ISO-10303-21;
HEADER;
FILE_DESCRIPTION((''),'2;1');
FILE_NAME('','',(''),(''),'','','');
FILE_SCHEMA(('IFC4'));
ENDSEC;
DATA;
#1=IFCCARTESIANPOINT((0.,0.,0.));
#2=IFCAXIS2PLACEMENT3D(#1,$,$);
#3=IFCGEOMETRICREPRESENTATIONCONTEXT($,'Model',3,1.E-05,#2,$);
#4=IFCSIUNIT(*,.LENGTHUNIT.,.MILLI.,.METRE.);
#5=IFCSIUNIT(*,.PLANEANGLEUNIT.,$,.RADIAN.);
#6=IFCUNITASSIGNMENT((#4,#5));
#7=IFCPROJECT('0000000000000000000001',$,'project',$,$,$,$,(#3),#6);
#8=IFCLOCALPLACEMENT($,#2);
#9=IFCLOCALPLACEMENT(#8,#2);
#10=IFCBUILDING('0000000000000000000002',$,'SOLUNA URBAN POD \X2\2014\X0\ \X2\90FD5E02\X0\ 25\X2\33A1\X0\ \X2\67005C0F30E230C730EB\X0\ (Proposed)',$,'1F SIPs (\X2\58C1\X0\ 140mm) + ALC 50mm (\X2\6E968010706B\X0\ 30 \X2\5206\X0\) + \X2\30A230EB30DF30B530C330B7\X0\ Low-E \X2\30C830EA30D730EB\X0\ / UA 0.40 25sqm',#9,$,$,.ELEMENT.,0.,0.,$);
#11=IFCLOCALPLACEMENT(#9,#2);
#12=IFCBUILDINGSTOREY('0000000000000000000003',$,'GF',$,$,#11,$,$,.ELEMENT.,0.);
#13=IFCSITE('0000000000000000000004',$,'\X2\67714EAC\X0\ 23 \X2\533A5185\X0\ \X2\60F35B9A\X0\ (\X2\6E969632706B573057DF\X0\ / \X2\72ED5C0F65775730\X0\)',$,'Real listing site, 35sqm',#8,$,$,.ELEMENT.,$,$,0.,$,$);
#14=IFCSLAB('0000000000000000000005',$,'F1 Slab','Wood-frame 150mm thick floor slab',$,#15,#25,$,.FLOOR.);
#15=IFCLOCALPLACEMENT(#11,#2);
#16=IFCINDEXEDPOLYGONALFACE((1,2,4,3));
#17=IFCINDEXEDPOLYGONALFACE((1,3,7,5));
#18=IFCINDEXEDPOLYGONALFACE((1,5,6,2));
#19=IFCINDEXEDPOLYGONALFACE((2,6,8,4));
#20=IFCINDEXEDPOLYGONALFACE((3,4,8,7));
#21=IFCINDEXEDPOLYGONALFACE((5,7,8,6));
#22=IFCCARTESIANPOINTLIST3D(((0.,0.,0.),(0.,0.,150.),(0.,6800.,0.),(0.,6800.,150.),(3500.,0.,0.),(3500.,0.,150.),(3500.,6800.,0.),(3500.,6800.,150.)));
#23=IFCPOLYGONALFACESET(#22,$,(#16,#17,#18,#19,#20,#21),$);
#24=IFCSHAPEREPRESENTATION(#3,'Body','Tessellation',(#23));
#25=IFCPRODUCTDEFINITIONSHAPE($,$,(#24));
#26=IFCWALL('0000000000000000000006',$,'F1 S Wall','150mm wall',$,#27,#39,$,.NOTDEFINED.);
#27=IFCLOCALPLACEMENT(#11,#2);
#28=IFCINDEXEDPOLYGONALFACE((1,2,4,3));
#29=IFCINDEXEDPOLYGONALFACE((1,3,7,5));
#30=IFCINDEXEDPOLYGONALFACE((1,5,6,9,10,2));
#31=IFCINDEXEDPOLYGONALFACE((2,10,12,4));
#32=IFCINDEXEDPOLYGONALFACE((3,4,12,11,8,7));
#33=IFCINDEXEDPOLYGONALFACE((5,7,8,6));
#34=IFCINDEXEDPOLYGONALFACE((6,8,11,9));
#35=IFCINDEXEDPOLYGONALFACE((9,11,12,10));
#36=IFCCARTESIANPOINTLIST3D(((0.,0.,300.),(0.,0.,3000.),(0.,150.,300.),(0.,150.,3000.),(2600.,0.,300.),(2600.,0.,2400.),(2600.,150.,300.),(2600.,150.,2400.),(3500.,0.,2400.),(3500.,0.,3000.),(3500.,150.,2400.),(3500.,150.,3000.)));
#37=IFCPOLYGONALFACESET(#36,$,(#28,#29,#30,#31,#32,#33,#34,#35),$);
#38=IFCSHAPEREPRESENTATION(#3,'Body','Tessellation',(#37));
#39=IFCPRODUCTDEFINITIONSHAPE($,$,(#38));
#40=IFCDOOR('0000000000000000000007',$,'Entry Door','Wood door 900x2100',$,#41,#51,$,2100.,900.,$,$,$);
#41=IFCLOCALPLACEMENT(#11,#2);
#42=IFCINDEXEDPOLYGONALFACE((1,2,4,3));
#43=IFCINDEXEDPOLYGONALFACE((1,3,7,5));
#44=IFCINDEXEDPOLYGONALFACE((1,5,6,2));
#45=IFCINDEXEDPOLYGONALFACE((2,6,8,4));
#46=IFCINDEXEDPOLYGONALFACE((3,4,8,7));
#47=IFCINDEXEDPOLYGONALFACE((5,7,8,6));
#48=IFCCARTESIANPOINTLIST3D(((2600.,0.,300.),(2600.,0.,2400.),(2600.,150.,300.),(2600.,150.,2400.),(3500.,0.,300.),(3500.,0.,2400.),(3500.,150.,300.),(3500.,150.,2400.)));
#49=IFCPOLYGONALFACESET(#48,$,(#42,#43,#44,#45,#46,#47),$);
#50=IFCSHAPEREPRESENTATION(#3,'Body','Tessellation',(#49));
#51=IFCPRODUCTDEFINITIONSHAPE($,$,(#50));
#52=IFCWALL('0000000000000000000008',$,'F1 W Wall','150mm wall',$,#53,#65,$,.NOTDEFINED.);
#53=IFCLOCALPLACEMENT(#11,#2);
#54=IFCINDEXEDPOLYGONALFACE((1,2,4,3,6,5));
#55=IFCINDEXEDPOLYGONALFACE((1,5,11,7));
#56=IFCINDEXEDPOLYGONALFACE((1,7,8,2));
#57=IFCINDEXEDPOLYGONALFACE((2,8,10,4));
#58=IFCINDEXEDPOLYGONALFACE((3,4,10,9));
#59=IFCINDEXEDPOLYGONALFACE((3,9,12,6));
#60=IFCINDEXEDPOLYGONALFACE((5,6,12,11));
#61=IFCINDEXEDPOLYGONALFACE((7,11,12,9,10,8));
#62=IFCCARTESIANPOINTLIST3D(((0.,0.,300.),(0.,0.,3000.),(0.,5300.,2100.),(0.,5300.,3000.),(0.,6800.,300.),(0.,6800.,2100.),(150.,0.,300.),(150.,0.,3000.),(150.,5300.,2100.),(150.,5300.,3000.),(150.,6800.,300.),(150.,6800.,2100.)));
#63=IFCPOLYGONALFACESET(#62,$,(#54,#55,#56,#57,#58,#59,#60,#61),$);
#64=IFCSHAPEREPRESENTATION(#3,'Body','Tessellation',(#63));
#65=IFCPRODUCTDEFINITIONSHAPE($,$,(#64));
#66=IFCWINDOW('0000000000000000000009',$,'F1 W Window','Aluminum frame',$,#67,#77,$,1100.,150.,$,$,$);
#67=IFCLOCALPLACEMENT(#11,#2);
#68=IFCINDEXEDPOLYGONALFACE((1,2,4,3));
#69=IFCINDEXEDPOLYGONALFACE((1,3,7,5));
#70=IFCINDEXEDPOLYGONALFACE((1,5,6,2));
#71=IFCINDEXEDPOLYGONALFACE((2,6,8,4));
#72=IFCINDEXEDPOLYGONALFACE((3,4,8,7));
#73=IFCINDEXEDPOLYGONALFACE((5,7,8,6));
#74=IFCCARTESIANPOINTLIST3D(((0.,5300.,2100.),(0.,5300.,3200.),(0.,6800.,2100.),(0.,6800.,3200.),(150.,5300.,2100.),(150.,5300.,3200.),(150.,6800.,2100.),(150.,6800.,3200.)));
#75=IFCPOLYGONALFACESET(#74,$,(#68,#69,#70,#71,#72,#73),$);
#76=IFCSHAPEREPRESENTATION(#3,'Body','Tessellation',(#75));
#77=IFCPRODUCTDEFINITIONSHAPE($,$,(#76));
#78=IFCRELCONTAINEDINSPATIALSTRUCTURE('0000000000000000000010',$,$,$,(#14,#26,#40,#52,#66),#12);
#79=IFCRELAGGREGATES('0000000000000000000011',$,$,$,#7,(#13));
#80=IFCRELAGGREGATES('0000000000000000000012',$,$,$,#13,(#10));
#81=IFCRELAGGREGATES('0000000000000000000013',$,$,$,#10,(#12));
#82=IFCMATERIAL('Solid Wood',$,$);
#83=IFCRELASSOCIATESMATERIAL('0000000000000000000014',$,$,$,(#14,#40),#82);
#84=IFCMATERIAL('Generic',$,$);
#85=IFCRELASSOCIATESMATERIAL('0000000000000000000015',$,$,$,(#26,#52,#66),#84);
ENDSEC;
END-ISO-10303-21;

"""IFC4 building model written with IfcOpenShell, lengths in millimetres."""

from ifc_helpers import new_model, si_unit, frame, frame_2d, origin, place, context, project, spatial, rectangle, extrude, material, element, fill, save


model = new_model("IFC4")

# Units and contexts
model_context = context("Model", 3, precision=1e-05, world=origin())
ifc_project = project(units=[si_unit("LENGTHUNIT", "METRE", prefix="MILLI"), si_unit("PLANEANGLEUNIT", "RADIAN")], contexts=[model_context])

# Site, building, storey
site_placement = place(None, origin())
site = spatial("IfcSite", under=ifc_project, at=site_placement, Name="東京 23 区内 想定 (準防火地域 / 狭小敷地)", ObjectType="Real listing site, 35sqm", CompositionType="ELEMENT", RefElevation=0.0)
building_placement = place(site_placement, origin())
building = spatial("IfcBuilding", under=site, at=building_placement, Name="SOLUNA URBAN POD — 都市 25㎡ 最小モデル (Proposed)", ObjectType="1F SIPs (壁 140mm) + ALC 50mm (準耐火 30 分) + アルミサッシ Low-E トリプル / UA 0.40 25sqm", CompositionType="ELEMENT", ElevationOfRefHeight=0.0, ElevationOfTerrain=0.0)
storey_placement = place(building_placement, origin())
storey = spatial("IfcBuildingStorey", under=building, at=storey_placement, Name="GF", CompositionType="ELEMENT", Elevation=0.0)

# Slab
ifc_material_1 = material(Name="Solid Wood")
slab_placement = place(storey_placement, origin())
element("IfcSlab", 1, at=slab_placement, inside=storey, material=ifc_material_1, Name="F1 Slab", Description="Wood-frame 150mm thick floor slab", PredefinedType="FLOOR", context=model_context, shape_type="SweptSolid", body=[
    extrude(rectangle(XDim=3500.0, YDim=6800.0, at=frame_2d((1750.0, 3400.0))), origin(), (0.0, 0.0, 1.0), 150.0),
])

# Shared definitions
ifc_material_2 = material(Name="Generic")

# Wall, opening, door
wall_1_placement = place(storey_placement, frame((0.0, 0.0, 150.0)))
wall_1 = element("IfcWall", 2, at=wall_1_placement, inside=storey, material=ifc_material_2, Name="F1 S Wall", Description="150mm wall", PredefinedType="NOTDEFINED", context=model_context, shape_type="SweptSolid", body=[
    extrude(rectangle(XDim=3500.0, YDim=150.0, at=frame_2d((1750.0, 75.0))), frame((0.0, 0.0, 150.0)), (0.0, 0.0, 1.0), 2700.0),
])
opening_1_placement = place(storey_placement, frame((1300.0, 0.0, 150.0)))
opening_1 = element("IfcOpeningElement", 3, at=opening_1_placement, cuts=wall_1, PredefinedType="NOTDEFINED", context=model_context, shape_type="SweptSolid", body=[
    extrude(rectangle(XDim=900.0, YDim=150.0, at=frame_2d((450.0, 75.0))), frame((1300.0, 0.0, 150.0)), (0.0, 0.0, 1.0), 2100.0),
])
door_placement = place(storey_placement, frame((1300.0, 0.0, 150.0)))
door = element("IfcDoor", 4, at=door_placement, inside=storey, material=ifc_material_1, Name="Entry Door", Description="Wood door 900x2100", OverallHeight=2100.0, OverallWidth=900.0, context=model_context, shape_type="SweptSolid", body=[
    extrude(rectangle(XDim=900.0, YDim=150.0, at=frame_2d((450.0, 75.0))), frame((1300.0, 0.0, 150.0)), (0.0, 0.0, 1.0), 2100.0),
])
fill(opening_1, door)

# Wall, opening, window
wall_2_placement = place(storey_placement, frame((0.0, 0.0, 150.0)))
wall_2 = element("IfcWall", 5, at=wall_2_placement, inside=storey, material=ifc_material_2, Name="F1 W Wall", Description="150mm wall", PredefinedType="NOTDEFINED", context=model_context, shape_type="SweptSolid", body=[
    extrude(rectangle(XDim=150.0, YDim=6800.0, at=frame_2d((75.0, 3400.0))), frame((0.0, 0.0, 150.0)), (0.0, 0.0, 1.0), 2700.0),
])
opening_2_placement = place(storey_placement, frame((0.0, 2650.0, 1050.0)))
opening_2 = element("IfcOpeningElement", 6, at=opening_2_placement, cuts=wall_2, PredefinedType="NOTDEFINED", context=model_context, shape_type="SweptSolid", body=[
    extrude(rectangle(XDim=150.0, YDim=1500.0, at=frame_2d((75.0, 750.0))), frame((0.0, 2650.0, 1050.0)), (0.0, 0.0, 1.0), 1100.0),
])
window_1_placement = place(storey_placement, frame((0.0, 2650.0, 1050.0)))
window_1 = element("IfcWindow", 7, at=window_1_placement, inside=storey, material=ifc_material_2, Name="F1 W Window", Description="Aluminum frame", OverallHeight=1100.0, OverallWidth=150.0, context=model_context, shape_type="SweptSolid", body=[
    extrude(rectangle(XDim=150.0, YDim=1500.0, at=frame_2d((75.0, 750.0))), frame((0.0, 2650.0, 1050.0)), (0.0, 0.0, 1.0), 1100.0),
])
fill(opening_2, window_1)

save(model, "model.ifc")
